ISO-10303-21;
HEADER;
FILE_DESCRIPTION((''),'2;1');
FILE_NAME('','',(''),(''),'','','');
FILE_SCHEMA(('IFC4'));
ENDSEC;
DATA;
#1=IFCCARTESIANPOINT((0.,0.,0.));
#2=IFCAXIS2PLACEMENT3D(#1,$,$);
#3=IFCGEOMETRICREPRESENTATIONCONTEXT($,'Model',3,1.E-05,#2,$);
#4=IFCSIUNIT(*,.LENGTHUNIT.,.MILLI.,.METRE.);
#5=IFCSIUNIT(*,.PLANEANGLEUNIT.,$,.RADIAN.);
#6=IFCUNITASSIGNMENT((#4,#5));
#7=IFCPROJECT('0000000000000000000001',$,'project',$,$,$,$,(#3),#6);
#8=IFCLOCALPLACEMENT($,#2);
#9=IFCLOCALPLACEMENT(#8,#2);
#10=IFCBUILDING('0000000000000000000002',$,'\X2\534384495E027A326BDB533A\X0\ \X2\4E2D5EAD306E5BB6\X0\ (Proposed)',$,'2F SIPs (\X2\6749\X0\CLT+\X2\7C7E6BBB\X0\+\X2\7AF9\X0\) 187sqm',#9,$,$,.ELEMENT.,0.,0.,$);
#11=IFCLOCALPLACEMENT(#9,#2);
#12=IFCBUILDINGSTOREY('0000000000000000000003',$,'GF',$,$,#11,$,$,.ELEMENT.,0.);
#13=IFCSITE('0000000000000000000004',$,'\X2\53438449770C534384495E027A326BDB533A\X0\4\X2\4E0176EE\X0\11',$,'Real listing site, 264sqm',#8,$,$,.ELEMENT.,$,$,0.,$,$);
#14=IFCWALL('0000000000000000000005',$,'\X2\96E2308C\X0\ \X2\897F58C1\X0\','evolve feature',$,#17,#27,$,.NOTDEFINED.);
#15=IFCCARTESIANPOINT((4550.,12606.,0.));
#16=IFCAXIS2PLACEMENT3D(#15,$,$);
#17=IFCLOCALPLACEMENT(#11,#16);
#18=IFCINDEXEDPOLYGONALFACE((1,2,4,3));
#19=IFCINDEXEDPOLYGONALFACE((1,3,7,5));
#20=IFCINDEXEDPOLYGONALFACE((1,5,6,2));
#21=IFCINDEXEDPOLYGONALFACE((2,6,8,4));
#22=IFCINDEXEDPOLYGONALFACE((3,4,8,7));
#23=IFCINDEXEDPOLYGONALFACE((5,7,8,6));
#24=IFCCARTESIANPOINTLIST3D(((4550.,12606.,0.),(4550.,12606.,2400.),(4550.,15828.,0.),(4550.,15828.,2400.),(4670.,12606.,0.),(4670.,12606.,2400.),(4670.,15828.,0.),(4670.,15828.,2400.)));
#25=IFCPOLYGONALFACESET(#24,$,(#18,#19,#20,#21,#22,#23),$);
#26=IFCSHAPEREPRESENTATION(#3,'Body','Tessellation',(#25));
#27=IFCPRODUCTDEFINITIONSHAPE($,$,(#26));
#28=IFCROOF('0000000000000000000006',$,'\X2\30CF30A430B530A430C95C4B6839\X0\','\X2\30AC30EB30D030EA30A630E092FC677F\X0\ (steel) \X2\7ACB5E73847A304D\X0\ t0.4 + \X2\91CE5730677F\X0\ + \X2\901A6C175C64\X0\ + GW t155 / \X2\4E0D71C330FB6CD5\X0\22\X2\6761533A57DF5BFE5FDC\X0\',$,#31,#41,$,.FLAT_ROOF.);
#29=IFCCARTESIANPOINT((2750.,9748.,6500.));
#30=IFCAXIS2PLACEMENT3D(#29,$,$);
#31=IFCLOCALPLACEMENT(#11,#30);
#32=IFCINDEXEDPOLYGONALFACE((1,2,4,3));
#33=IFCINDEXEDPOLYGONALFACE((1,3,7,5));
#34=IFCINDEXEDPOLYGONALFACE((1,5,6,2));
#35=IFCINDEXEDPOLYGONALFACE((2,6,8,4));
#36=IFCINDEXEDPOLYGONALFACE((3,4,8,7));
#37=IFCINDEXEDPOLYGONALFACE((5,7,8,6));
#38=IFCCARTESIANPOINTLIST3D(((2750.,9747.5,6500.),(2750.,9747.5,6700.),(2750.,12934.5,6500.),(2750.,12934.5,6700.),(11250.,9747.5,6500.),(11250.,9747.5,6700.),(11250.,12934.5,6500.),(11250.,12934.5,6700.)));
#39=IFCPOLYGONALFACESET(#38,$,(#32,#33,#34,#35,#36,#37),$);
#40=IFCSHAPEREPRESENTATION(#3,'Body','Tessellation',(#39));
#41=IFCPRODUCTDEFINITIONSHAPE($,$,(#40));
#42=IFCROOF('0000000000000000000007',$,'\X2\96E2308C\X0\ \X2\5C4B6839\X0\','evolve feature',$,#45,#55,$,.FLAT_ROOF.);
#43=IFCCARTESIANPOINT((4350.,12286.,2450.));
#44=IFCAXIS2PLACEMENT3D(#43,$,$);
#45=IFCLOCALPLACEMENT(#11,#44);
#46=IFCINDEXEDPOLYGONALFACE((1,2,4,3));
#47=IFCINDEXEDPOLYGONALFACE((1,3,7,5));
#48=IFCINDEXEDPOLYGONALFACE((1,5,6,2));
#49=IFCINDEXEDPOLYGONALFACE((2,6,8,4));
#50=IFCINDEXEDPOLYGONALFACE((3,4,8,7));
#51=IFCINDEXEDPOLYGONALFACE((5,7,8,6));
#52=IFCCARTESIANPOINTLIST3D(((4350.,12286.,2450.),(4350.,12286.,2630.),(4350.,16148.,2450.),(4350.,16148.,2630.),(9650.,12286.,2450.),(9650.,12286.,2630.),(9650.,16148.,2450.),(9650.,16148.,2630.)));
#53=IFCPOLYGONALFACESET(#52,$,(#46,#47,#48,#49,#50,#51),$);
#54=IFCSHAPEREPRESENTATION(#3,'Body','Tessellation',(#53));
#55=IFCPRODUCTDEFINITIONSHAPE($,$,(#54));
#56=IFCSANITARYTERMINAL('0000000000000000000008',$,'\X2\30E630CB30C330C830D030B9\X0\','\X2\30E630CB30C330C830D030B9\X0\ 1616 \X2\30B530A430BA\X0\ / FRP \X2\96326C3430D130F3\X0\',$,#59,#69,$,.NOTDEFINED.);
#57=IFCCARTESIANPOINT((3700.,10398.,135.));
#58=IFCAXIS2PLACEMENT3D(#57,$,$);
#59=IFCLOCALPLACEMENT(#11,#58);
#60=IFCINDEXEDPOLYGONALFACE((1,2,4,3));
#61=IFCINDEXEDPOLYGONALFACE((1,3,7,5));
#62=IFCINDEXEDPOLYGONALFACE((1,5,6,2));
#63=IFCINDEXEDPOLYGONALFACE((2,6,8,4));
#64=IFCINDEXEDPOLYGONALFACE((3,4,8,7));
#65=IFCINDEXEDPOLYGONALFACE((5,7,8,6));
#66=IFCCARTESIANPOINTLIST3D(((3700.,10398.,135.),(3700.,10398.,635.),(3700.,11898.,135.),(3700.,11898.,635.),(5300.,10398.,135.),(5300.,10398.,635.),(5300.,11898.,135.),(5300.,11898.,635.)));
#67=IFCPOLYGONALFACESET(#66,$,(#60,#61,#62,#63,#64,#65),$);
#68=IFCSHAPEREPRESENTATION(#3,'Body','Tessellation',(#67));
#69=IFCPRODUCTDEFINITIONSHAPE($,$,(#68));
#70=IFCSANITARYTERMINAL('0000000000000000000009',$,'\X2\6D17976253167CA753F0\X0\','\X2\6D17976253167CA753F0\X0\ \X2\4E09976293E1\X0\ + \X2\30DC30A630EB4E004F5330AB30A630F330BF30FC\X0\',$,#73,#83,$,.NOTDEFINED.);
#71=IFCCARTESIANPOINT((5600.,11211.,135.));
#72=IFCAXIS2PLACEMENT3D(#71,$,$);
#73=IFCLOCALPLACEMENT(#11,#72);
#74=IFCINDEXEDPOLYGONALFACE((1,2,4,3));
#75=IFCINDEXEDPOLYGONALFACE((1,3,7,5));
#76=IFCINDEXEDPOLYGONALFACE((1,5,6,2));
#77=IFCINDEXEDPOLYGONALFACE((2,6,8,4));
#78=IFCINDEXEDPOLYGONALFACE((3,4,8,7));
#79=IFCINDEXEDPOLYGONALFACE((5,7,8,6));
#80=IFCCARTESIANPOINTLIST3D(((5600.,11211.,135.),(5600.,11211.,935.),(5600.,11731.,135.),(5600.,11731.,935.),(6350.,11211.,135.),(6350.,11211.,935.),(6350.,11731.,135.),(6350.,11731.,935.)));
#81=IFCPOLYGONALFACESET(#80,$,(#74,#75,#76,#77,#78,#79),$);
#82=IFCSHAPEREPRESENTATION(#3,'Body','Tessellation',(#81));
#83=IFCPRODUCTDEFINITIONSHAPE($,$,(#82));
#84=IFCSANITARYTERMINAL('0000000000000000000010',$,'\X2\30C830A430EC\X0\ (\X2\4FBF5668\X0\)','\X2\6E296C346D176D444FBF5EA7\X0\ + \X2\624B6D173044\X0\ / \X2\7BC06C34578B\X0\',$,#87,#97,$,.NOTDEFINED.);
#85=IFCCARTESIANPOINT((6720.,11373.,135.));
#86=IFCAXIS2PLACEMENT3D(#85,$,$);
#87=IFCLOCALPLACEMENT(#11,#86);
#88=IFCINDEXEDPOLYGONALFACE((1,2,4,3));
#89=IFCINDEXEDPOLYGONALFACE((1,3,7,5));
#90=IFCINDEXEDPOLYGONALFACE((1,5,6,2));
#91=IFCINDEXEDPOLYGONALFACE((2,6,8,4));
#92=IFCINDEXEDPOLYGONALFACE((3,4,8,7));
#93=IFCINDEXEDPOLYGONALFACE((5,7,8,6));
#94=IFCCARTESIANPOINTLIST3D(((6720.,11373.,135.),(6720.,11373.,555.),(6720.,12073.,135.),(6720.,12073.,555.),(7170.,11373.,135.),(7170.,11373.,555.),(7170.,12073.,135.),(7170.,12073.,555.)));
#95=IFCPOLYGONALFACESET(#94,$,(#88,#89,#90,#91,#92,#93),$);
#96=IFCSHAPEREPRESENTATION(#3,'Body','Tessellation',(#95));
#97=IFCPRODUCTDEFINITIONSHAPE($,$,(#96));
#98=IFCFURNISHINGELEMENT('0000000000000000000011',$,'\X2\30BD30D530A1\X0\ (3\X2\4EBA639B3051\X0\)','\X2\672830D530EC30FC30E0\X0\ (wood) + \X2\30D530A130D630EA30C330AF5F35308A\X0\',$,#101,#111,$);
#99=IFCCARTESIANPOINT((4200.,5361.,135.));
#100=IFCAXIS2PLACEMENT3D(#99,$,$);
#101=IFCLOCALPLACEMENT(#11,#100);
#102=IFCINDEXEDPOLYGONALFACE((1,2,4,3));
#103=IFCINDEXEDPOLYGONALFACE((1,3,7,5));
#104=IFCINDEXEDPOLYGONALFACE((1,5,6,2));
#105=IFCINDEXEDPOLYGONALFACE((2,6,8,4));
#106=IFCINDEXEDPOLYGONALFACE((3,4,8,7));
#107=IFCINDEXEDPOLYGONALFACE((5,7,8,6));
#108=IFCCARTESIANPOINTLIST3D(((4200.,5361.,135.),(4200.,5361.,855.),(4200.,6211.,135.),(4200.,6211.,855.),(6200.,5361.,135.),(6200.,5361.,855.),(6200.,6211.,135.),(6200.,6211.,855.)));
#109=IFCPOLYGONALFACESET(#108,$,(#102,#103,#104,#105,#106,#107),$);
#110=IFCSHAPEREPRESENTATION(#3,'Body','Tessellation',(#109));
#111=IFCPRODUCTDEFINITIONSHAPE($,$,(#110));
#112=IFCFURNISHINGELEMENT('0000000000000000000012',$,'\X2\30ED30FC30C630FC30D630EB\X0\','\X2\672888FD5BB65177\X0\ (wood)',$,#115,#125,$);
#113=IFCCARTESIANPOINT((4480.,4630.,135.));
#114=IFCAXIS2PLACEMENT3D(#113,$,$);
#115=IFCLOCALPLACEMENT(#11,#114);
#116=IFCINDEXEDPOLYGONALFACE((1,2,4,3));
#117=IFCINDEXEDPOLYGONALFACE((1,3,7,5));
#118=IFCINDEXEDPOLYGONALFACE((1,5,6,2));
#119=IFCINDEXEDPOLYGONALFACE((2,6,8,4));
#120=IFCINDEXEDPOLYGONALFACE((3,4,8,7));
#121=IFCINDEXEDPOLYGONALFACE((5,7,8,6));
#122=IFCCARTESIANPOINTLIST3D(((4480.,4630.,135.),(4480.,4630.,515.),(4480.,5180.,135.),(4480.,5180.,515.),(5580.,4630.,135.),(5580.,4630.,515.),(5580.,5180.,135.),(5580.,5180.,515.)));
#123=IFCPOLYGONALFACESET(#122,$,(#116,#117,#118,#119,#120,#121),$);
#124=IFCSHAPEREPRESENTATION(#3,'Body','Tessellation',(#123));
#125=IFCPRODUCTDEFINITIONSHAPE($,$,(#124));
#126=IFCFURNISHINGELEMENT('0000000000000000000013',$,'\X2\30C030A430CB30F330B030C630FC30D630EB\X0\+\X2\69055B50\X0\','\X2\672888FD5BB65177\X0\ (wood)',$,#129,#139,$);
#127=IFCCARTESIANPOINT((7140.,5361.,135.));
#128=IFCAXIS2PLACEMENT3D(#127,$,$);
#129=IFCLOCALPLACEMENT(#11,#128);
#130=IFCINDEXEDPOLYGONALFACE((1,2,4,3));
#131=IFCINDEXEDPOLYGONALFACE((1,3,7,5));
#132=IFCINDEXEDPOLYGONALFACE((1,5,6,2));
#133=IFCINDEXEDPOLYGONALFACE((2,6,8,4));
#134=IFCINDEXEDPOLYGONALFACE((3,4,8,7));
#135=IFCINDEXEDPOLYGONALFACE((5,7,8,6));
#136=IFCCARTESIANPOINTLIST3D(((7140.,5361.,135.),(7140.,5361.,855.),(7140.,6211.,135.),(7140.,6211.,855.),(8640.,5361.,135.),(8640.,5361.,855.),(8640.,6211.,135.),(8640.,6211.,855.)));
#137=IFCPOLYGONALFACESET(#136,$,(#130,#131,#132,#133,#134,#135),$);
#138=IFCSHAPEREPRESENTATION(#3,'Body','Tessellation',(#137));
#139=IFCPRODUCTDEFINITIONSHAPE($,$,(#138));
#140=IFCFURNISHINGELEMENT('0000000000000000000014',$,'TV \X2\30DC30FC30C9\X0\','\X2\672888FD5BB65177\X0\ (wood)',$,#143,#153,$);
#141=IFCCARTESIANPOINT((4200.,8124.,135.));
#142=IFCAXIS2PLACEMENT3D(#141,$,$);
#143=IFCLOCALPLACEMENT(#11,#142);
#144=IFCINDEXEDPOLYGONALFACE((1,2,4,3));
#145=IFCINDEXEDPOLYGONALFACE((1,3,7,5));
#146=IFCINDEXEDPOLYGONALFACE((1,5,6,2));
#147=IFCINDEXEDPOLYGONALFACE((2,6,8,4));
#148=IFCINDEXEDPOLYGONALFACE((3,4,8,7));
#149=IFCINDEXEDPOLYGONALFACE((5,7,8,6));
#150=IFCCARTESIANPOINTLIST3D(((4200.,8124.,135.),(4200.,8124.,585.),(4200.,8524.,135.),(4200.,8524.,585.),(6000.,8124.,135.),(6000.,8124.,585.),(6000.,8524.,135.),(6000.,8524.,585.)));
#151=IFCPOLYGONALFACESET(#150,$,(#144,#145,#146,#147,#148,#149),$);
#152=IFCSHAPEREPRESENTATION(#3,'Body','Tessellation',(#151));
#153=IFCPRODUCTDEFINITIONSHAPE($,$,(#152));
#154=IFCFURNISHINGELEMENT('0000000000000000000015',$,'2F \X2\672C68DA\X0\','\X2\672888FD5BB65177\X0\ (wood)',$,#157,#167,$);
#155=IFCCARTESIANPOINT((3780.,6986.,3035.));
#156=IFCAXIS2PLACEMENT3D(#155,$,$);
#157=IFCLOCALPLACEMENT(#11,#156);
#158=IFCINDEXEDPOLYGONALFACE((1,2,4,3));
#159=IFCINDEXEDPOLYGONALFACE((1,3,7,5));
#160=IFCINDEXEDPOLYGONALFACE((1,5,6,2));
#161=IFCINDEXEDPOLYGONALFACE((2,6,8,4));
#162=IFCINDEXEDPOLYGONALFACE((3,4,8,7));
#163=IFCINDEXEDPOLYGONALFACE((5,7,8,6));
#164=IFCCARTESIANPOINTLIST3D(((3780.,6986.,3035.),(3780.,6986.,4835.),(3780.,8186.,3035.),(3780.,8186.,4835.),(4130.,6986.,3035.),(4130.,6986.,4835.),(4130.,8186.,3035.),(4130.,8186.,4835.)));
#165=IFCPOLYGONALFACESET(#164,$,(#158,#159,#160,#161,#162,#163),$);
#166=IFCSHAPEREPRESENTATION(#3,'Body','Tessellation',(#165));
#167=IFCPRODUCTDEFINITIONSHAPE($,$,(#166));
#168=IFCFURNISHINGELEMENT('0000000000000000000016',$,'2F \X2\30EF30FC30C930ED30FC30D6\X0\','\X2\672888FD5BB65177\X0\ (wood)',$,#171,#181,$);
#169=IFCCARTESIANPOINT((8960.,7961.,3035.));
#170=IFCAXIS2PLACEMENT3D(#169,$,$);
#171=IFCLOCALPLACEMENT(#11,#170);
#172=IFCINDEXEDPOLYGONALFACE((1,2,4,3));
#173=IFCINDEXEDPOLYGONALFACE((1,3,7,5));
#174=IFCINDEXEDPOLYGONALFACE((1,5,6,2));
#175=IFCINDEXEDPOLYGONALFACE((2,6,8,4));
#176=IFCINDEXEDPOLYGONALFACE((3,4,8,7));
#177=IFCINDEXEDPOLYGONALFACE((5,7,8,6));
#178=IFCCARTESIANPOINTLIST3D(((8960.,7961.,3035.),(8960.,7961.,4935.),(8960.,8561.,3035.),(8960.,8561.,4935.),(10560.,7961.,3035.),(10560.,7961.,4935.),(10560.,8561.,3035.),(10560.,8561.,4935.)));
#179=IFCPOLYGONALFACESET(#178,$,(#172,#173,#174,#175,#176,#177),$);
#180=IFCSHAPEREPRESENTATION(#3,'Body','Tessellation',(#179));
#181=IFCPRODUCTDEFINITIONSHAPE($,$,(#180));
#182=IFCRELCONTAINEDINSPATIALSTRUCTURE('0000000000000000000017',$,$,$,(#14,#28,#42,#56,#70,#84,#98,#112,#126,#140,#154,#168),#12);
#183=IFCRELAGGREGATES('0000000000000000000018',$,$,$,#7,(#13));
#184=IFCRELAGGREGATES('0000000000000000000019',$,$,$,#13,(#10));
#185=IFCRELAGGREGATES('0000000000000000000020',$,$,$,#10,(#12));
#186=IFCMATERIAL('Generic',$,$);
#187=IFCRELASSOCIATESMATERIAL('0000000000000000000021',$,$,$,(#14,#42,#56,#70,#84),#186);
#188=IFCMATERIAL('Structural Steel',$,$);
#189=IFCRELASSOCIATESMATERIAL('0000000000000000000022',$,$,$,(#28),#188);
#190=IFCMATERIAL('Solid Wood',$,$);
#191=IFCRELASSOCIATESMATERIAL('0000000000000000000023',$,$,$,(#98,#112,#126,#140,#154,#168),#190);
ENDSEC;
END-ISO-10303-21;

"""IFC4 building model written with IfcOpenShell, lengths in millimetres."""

from ifc_helpers import new_model, si_unit, frame, frame_2d, origin, place, context, project, spatial, rectangle, extrude, material, element, save


model = new_model("IFC4")

# Units and contexts
model_context = context("Model", 3, precision=1e-05, world=origin())
ifc_project = project(units=[si_unit("LENGTHUNIT", "METRE", prefix="MILLI"), si_unit("PLANEANGLEUNIT", "RADIAN")], contexts=[model_context])

# Site, building, storey
site_placement = place(None, origin())
site = spatial("IfcSite", under=ifc_project, at=site_placement, Name="千葉県千葉市稲毛区4丁目11", ObjectType="Real listing site, 264sqm", CompositionType="ELEMENT", RefElevation=0.0)
building_placement = place(site_placement, origin())
building = spatial("IfcBuilding", under=site, at=building_placement, Name="千葉市稲毛区 中庭の家 (Proposed)", ObjectType="2F SIPs (杉CLT+籾殻+竹) 187sqm", CompositionType="ELEMENT", ElevationOfRefHeight=0.0, ElevationOfTerrain=0.0)
storey_placement = place(building_placement, origin())
storey = spatial("IfcBuildingStorey", under=building, at=storey_placement, Name="GF", CompositionType="ELEMENT", Elevation=0.0)

# Shared definitions
ifc_material_1 = material(Name="Generic")

# Shared definitions
ifc_material_2 = material(Name="Solid Wood")

# Wall
wall_1_placement = place(storey_placement, frame((4550.0, 12606.0, 0.0)))
element("IfcWall", 1, at=wall_1_placement, inside=storey, material=ifc_material_1, Name="離れ 西壁", Description="evolve feature", PredefinedType="NOTDEFINED", context=model_context, shape_type="SweptSolid", body=[
    extrude(rectangle(XDim=120.0, YDim=3222.0, at=frame_2d((60.0, 1611.0))), frame((4550.0, 12606.0, 0.0)), (0.0, 0.0, 1.0), 2400.0),
])

# Roofs
ifc_material_3 = material(Name="Structural Steel")
roof_1_placement = place(storey_placement, frame((2750.0, 9748.0, 6500.0)))
element("IfcRoof", 2, at=roof_1_placement, inside=storey, material=ifc_material_3, Name="ハイサイド屋根", Description="ガルバリウム鋼板 (steel) 立平葺き t0.4 + 野地板 + 通気層 + GW t155 / 不燃・法22条区域対応", PredefinedType="FLAT_ROOF", context=model_context, shape_type="SweptSolid", body=[
    extrude(rectangle(XDim=8500.0, YDim=3187.0, at=frame_2d((4250.0, 1593.0))), frame((2750.0, 9748.0, 6500.0)), (0.0, 0.0, 1.0), 200.0),
])
roof_2_placement = place(storey_placement, frame((4350.0, 12286.0, 2450.0)))
element("IfcRoof", 3, at=roof_2_placement, inside=storey, material=ifc_material_1, Name="離れ 屋根", Description="evolve feature", PredefinedType="FLAT_ROOF", context=model_context, shape_type="SweptSolid", body=[
    extrude(rectangle(XDim=5300.0, YDim=3862.0, at=frame_2d((2650.0, 1931.0))), frame((4350.0, 12286.0, 2450.0)), (0.0, 0.0, 1.0), 180.0),
])

# Sanitary terminals
sanitary_terminal_1_placement = place(storey_placement, frame((3700.0, 10398.0, 135.0)))
element("IfcSanitaryTerminal", 4, at=sanitary_terminal_1_placement, inside=storey, material=ifc_material_1, Name="ユニットバス", Description="ユニットバス 1616 サイズ / FRP 防水パン", PredefinedType="NOTDEFINED", context=model_context, shape_type="SweptSolid", body=[
    extrude(rectangle(XDim=1600.0, YDim=1500.0, at=frame_2d((800.0, 750.0))), frame((3700.0, 10398.0, 135.0)), (0.0, 0.0, 1.0), 500.0),
])
sanitary_terminal_2_placement = place(storey_placement, frame((5600.0, 11211.0, 135.0)))
element("IfcSanitaryTerminal", 5, at=sanitary_terminal_2_placement, inside=storey, material=ifc_material_1, Name="洗面化粧台", Description="洗面化粧台 三面鏡 + ボウル一体カウンター", PredefinedType="NOTDEFINED", context=model_context, shape_type="SweptSolid", body=[
    extrude(rectangle(XDim=750.0, YDim=520.0, at=frame_2d((375.0, 260.0))), frame((5600.0, 11211.0, 135.0)), (0.0, 0.0, 1.0), 800.0),
])
sanitary_terminal_3_placement = place(storey_placement, frame((6720.0, 11373.0, 135.0)))
element("IfcSanitaryTerminal", 6, at=sanitary_terminal_3_placement, inside=storey, material=ifc_material_1, Name="トイレ (便器)", Description="温水洗浄便座 + 手洗い / 節水型", PredefinedType="NOTDEFINED", context=model_context, shape_type="SweptSolid", body=[
    extrude(rectangle(XDim=450.0, YDim=700.0, at=frame_2d((225.0, 350.0))), frame((6720.0, 11373.0, 135.0)), (0.0, 0.0, 1.0), 420.0),
])

# Furnishing elements
furnishing_1_placement = place(storey_placement, frame((4200.0, 5361.0, 135.0)))
element("IfcFurnishingElement", 7, at=furnishing_1_placement, inside=storey, material=ifc_material_2, Name="ソファ (3人掛け)", Description="木フレーム (wood) + ファブリック張り", context=model_context, shape_type="SweptSolid", body=[
    extrude(rectangle(XDim=2000.0, YDim=850.0, at=frame_2d((1000.0, 425.0))), frame((4200.0, 5361.0, 135.0)), (0.0, 0.0, 1.0), 720.0),
])
furnishing_2_placement = place(storey_placement, frame((4480.0, 4630.0, 135.0)))
element("IfcFurnishingElement", 8, at=furnishing_2_placement, inside=storey, material=ifc_material_2, Name="ローテーブル", Description="木製家具 (wood)", context=model_context, shape_type="SweptSolid", body=[
    extrude(rectangle(XDim=1100.0, YDim=550.0, at=frame_2d((550.0, 275.0))), frame((4480.0, 4630.0, 135.0)), (0.0, 0.0, 1.0), 380.0),
])
furnishing_3_placement = place(storey_placement, frame((7140.0, 5361.0, 135.0)))
element("IfcFurnishingElement", 9, at=furnishing_3_placement, inside=storey, material=ifc_material_2, Name="ダイニングテーブル+椅子", Description="木製家具 (wood)", context=model_context, shape_type="SweptSolid", body=[
    extrude(rectangle(XDim=1500.0, YDim=850.0, at=frame_2d((750.0, 425.0))), frame((7140.0, 5361.0, 135.0)), (0.0, 0.0, 1.0), 720.0),
])
furnishing_4_placement = place(storey_placement, frame((4200.0, 8124.0, 135.0)))
element("IfcFurnishingElement", 10, at=furnishing_4_placement, inside=storey, material=ifc_material_2, Name="TV ボード", Description="木製家具 (wood)", context=model_context, shape_type="SweptSolid", body=[
    extrude(rectangle(XDim=1800.0, YDim=400.0, at=frame_2d((900.0, 200.0))), frame((4200.0, 8124.0, 135.0)), (0.0, 0.0, 1.0), 450.0),
])
furnishing_5_placement = place(storey_placement, frame((3780.0, 6986.0, 3035.0)))
element("IfcFurnishingElement", 11, at=furnishing_5_placement, inside=storey, material=ifc_material_2, Name="2F 本棚", Description="木製家具 (wood)", context=model_context, shape_type="SweptSolid", body=[
    extrude(rectangle(XDim=350.0, YDim=1200.0, at=frame_2d((175.0, 600.0))), frame((3780.0, 6986.0, 3035.0)), (0.0, 0.0, 1.0), 1800.0),
])
furnishing_6_placement = place(storey_placement, frame((8960.0, 7961.0, 3035.0)))
element("IfcFurnishingElement", 12, at=furnishing_6_placement, inside=storey, material=ifc_material_2, Name="2F ワードローブ", Description="木製家具 (wood)", context=model_context, shape_type="SweptSolid", body=[
    extrude(rectangle(XDim=1600.0, YDim=600.0, at=frame_2d((800.0, 300.0))), frame((8960.0, 7961.0, 3035.0)), (0.0, 0.0, 1.0), 1900.0),
])

save(model, "model.ifc")
